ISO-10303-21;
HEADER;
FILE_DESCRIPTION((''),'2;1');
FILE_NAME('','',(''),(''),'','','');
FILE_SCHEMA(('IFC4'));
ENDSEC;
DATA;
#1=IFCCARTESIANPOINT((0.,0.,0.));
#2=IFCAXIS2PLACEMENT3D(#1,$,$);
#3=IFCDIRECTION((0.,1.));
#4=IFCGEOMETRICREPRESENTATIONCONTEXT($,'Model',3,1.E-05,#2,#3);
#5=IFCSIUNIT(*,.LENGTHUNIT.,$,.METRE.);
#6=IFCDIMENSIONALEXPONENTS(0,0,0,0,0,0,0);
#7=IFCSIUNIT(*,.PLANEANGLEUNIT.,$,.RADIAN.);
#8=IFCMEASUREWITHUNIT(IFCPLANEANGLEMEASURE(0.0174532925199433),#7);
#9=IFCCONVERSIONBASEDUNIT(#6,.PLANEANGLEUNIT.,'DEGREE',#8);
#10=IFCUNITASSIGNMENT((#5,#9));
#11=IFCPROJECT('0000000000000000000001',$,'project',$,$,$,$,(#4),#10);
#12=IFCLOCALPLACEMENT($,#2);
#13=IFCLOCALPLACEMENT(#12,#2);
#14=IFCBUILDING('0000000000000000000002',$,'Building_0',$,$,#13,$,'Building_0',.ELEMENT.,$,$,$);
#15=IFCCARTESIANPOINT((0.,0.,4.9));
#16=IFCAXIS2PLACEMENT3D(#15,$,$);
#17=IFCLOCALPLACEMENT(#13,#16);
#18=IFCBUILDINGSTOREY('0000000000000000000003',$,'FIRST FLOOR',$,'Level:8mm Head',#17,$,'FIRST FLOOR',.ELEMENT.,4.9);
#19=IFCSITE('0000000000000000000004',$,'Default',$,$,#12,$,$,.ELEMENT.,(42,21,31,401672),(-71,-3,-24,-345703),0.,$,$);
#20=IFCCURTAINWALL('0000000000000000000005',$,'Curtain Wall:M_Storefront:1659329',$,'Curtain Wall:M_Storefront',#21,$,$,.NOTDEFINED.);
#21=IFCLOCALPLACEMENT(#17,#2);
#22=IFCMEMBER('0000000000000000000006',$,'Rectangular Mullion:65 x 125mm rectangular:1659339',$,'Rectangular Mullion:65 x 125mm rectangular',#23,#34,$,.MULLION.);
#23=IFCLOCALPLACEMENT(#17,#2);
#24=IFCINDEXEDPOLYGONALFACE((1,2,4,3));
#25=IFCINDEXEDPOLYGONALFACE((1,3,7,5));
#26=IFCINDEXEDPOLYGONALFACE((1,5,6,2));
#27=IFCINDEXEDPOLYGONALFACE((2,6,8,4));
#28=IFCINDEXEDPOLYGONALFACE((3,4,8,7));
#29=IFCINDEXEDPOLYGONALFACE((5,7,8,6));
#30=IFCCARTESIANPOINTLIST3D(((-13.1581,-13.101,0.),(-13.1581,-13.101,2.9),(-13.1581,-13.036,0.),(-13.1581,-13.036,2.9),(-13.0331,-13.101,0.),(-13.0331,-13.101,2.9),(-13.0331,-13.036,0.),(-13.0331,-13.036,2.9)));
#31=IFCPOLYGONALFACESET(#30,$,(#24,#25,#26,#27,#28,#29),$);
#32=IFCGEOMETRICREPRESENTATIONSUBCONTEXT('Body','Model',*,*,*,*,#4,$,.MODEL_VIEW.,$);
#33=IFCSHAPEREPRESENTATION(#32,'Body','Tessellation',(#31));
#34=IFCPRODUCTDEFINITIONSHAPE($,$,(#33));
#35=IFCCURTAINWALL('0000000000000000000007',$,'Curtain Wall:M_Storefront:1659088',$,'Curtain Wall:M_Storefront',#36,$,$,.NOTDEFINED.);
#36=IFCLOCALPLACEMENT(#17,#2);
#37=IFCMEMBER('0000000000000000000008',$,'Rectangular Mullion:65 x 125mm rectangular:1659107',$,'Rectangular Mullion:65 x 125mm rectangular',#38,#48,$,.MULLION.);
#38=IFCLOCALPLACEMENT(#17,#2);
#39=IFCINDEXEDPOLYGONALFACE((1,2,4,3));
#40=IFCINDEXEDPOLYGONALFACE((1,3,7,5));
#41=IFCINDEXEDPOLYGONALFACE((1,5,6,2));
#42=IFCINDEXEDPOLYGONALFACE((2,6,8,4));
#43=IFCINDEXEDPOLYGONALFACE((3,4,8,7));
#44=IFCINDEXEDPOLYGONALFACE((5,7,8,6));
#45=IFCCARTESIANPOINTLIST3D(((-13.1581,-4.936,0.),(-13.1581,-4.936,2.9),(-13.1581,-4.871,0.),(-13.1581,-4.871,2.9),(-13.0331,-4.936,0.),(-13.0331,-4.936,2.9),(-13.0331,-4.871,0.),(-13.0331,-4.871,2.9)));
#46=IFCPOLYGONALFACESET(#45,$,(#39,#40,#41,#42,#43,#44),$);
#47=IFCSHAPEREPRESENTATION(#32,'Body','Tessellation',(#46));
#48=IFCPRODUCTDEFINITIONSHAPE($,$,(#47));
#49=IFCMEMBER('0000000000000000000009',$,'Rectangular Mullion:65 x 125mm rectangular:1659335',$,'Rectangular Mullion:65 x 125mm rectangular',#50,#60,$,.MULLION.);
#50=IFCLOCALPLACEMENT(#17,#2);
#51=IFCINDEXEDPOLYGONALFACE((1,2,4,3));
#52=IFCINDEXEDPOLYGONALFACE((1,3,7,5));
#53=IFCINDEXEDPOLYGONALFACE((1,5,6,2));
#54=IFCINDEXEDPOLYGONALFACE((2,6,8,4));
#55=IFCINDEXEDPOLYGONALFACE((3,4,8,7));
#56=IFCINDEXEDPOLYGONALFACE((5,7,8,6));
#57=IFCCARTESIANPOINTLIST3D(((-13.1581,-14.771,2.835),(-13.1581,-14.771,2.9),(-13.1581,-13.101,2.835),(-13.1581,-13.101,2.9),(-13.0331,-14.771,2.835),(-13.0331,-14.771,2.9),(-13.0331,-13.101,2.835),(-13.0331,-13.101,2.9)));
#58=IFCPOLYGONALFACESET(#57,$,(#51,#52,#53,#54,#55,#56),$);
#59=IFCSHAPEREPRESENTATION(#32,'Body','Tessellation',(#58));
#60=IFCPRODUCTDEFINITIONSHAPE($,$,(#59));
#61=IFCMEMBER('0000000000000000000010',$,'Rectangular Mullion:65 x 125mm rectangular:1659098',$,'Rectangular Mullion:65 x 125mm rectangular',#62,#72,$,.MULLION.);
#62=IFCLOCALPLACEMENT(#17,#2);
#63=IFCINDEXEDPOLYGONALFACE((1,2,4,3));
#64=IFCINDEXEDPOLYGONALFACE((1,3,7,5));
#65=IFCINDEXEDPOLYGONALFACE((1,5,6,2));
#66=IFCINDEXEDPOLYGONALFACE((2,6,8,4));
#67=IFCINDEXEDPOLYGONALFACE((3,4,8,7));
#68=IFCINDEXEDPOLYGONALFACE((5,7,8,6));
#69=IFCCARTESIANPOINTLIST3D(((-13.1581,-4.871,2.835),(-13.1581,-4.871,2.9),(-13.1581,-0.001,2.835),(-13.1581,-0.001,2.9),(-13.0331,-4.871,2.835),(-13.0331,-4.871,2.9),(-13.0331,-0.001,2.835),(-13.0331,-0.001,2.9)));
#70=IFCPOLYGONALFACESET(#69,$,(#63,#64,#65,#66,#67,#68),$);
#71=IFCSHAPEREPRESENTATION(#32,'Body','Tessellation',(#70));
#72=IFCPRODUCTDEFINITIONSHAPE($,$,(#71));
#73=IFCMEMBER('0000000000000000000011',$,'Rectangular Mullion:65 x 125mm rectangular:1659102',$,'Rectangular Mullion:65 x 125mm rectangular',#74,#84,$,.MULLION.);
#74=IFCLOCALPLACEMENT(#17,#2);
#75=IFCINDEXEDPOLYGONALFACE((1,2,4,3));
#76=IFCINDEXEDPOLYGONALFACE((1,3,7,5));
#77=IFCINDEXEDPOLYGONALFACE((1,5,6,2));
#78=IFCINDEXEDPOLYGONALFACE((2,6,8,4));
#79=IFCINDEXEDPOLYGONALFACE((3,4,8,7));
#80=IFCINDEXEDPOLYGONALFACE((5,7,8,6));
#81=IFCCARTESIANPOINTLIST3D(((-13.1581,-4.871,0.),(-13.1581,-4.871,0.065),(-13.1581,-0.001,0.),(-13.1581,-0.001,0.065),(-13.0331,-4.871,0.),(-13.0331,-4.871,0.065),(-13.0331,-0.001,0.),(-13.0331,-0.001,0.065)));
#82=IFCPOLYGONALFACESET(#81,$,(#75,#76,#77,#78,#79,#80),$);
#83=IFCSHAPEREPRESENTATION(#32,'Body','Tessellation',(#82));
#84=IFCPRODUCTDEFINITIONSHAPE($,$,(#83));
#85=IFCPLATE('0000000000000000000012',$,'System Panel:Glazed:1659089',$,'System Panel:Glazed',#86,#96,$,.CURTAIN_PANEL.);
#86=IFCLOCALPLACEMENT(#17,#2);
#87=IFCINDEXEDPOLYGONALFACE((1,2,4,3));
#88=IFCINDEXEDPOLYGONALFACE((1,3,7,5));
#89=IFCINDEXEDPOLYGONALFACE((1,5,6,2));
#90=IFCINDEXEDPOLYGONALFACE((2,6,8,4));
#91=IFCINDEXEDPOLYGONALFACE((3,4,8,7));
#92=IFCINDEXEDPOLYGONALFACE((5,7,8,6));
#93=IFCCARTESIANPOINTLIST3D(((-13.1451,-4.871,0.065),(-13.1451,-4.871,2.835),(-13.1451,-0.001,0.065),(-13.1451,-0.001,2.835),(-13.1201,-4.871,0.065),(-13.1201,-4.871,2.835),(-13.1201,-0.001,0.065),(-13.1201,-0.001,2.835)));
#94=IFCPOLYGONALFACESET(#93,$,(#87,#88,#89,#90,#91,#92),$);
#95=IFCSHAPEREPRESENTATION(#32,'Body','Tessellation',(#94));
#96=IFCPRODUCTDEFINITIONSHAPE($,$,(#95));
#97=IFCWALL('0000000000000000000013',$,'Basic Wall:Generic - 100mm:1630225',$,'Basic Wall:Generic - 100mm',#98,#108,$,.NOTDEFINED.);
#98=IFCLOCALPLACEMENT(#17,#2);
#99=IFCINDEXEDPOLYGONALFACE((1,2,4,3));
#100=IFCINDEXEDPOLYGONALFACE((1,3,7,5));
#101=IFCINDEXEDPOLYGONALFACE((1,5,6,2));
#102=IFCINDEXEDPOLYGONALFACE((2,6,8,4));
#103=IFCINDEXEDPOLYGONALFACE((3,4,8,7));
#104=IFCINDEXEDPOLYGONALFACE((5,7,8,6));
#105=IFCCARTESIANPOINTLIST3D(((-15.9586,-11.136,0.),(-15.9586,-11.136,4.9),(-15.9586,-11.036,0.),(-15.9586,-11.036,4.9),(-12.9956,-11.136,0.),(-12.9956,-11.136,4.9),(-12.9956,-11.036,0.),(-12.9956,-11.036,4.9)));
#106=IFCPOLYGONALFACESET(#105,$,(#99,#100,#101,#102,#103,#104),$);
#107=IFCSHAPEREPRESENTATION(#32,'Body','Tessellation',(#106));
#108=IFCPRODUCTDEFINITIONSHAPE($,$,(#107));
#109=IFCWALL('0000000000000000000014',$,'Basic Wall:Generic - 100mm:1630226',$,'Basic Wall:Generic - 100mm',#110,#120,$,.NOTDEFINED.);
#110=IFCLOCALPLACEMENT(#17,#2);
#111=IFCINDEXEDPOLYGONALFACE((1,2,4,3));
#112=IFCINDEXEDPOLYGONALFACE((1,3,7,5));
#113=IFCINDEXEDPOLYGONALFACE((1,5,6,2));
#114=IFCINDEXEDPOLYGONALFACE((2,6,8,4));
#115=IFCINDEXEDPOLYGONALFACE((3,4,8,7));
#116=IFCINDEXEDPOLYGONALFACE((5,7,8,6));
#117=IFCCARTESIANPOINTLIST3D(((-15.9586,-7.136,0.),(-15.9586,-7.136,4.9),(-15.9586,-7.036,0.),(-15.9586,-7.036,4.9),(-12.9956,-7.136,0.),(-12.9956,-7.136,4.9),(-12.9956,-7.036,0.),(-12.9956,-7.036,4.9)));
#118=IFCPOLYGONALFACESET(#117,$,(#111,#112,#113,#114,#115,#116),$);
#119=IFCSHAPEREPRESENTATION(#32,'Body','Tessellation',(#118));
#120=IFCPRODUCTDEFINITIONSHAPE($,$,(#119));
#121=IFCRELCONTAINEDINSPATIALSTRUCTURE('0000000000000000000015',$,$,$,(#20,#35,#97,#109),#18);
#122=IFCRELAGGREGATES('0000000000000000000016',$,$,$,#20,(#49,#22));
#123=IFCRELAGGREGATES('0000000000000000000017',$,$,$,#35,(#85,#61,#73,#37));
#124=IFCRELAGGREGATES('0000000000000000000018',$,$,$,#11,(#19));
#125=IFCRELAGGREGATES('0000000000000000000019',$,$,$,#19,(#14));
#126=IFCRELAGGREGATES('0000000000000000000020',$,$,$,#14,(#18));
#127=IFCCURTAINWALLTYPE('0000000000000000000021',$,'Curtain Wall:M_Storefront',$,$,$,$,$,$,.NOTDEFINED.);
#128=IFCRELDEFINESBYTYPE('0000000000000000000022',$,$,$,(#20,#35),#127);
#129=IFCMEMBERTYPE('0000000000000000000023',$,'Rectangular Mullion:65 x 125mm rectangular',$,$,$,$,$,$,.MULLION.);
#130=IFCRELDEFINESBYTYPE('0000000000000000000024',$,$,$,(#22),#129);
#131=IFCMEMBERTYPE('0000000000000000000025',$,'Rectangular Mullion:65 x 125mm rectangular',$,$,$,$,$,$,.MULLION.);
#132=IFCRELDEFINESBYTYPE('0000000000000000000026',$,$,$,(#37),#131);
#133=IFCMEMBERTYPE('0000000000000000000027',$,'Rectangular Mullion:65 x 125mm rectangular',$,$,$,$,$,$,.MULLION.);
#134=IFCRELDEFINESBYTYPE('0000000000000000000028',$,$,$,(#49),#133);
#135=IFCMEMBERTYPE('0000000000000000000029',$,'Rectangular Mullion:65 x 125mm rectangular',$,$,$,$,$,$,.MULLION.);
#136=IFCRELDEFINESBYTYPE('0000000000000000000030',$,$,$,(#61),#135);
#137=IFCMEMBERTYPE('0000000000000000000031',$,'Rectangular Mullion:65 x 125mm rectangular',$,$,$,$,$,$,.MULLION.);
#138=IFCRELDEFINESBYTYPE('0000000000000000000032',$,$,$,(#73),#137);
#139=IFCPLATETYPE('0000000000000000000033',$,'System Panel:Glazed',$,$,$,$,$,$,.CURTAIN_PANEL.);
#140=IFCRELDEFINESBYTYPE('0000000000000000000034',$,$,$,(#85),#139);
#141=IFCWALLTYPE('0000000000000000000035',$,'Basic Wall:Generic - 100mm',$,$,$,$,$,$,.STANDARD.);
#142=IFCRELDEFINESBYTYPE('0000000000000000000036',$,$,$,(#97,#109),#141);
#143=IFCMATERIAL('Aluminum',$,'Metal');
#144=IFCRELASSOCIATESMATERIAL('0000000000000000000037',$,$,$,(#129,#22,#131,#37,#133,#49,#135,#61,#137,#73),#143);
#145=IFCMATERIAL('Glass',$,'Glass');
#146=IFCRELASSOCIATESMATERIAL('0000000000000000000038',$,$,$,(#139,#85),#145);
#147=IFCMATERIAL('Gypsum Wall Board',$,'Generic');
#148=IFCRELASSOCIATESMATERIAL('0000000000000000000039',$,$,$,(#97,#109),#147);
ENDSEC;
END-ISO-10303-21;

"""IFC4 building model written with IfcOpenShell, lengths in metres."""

from ifc_helpers import new_model, entity, si_unit, converted_unit, direction, frame, origin, place, context, subcontext, project, spatial, indexed_curve, outline, extrude, source, transform, mapped, material, type_object, type_shapes, element, aggregate, save


model = new_model("IFC4")

# Units and contexts
model_context = context("Model", 3, precision=1e-05, world=origin(), true_north=direction((0.0, 1.0)))
body_context = subcontext(model_context, "Body", "Model", "MODEL_VIEW")
ifc_project = project(units=[si_unit("LENGTHUNIT", "METRE"), converted_unit("PLANEANGLEUNIT", "DEGREE", entity("IfcPlaneAngleMeasure", 0.0174532925199433), si_unit("PLANEANGLEUNIT", "RADIAN"), dimensions=[0, 0, 0, 0, 0, 0, 0])], contexts=[model_context])

# Site, building, storey
site_placement = place(None, origin())
site = spatial("IfcSite", under=ifc_project, at=site_placement, Name="Default", CompositionType="ELEMENT", RefLatitude=(42, 21, 31, 401672), RefLongitude=(-71, -3, -24, -345703), RefElevation=0.0)
building_placement = place(site_placement, origin())
building = spatial("IfcBuilding", under=site, at=building_placement, Name="Building_0", LongName="Building_0", CompositionType="ELEMENT")
storey_placement = place(building_placement, frame((0.0, 0.0, 4.9)))
storey = spatial("IfcBuildingStorey", under=building, at=storey_placement, Name="FIRST FLOOR", ObjectType="Level:8mm Head", LongName="FIRST FLOOR", CompositionType="ELEMENT", Elevation=4.9)

# Curtain walls, members
curtain_wall_type = type_object("IfcCurtainWallType", Name="Curtain Wall:M_Storefront", PredefinedType="NOTDEFINED")
curtain_wall_1_placement = place(storey_placement, frame((0.0, 0.0, -4.9)))
curtain_wall_1 = element("IfcCurtainWall", 1, at=curtain_wall_1_placement, inside=storey, type_object=curtain_wall_type, Name="Curtain Wall:M_Storefront:1659329", ObjectType="Curtain Wall:M_Storefront", PredefinedType="NOTDEFINED")
ifc_material_1 = material(Name="Aluminum", Category="Metal")
member_type_1 = type_object("IfcMemberType", Name="Rectangular Mullion:65 x 125mm rectangular", PredefinedType="MULLION", material=ifc_material_1)
shared_shape_1 = source(origin(), body_context, "Body", "SweptSolid", [
    extrude(outline(indexed_curve([(-0.0325, -0.0625), (0.0325, -0.0625), (0.0325, 0.0625), (-0.0325, 0.0625), (-0.0325, -0.0625)], self_intersect=False)), frame((-0.0325, 0.0, -2.9), z_axis=(0.0, 0.0, 1.0), x_axis=(-1.0, 0.0, 0.0)), (0.0, 0.0, 1.0), 2.9),
])
type_shapes(member_type_1, [shared_shape_1])
member_1_placement = place(curtain_wall_1_placement, frame((-13.0956, -13.036, 4.9), z_axis=(0.0, 0.0, -1.0), x_axis=(0.0, 1.0, 0.0)))
member_1 = element("IfcMember", 2, at=member_1_placement, type_object=member_type_1, material=ifc_material_1, Name="Rectangular Mullion:65 x 125mm rectangular:1659339", ObjectType="Rectangular Mullion:65 x 125mm rectangular", PredefinedType="MULLION", context=body_context, shape_type="MappedRepresentation", body=[
    mapped(shared_shape_1, transform((0.0, 0.0, 0.0), scale=1.0)),
])
curtain_wall_2_placement = place(storey_placement, frame((0.0, 0.0, -4.9)))
curtain_wall_2 = element("IfcCurtainWall", 3, at=curtain_wall_2_placement, inside=storey, type_object=curtain_wall_type, Name="Curtain Wall:M_Storefront:1659088", ObjectType="Curtain Wall:M_Storefront", PredefinedType="NOTDEFINED")
member_type_2 = type_object("IfcMemberType", Name="Rectangular Mullion:65 x 125mm rectangular", PredefinedType="MULLION", material=ifc_material_1)
shared_shape_2 = source(origin(), body_context, "Body", "SweptSolid", [
    extrude(outline(indexed_curve([(-0.0325, -0.0625), (0.0325, -0.0625), (0.0325, 0.0625), (-0.0325, 0.0625), (-0.0325, -0.0625)], self_intersect=False)), frame((-0.0325, 0.0, -2.9), z_axis=(0.0, 0.0, 1.0), x_axis=(-1.0, 0.0, 0.0)), (0.0, 0.0, 1.0), 2.9),
])
type_shapes(member_type_2, [shared_shape_2])
member_2_placement = place(curtain_wall_2_placement, frame((-13.0956, -4.936, 7.8), z_axis=(0.0, 0.0, 1.0), x_axis=(0.0, -1.0, 0.0)))
member_2 = element("IfcMember", 4, at=member_2_placement, type_object=member_type_2, material=ifc_material_1, Name="Rectangular Mullion:65 x 125mm rectangular:1659107", ObjectType="Rectangular Mullion:65 x 125mm rectangular", PredefinedType="MULLION", context=body_context, shape_type="MappedRepresentation", body=[
    mapped(shared_shape_2, transform((0.0, 0.0, 0.0), scale=1.0)),
])

# Members
member_type_3 = type_object("IfcMemberType", Name="Rectangular Mullion:65 x 125mm rectangular", PredefinedType="MULLION", material=ifc_material_1)
shared_shape_3 = source(origin(), body_context, "Body", "SweptSolid", [
    extrude(outline(indexed_curve([(-0.0325, -0.0625), (0.0325, -0.0625), (0.0325, 0.0625), (-0.0325, 0.0625), (-0.0325, -0.0625)], self_intersect=False)), frame((-0.0325, 0.0, -1.67), z_axis=(0.0, 0.0, 1.0), x_axis=(-1.0, 0.0, 0.0)), (0.0, 0.0, 1.0), 1.67),
])
type_shapes(member_type_3, [shared_shape_3])
member_3_placement = place(curtain_wall_1_placement, frame((-13.0956, -13.101, 7.8), z_axis=(0.0, 1.0, 0.0), x_axis=(0.0, 0.0, 1.0)))
member_3 = element("IfcMember", 5, at=member_3_placement, type_object=member_type_3, material=ifc_material_1, Name="Rectangular Mullion:65 x 125mm rectangular:1659335", ObjectType="Rectangular Mullion:65 x 125mm rectangular", PredefinedType="MULLION", context=body_context, shape_type="MappedRepresentation", body=[
    mapped(shared_shape_3, transform((0.0, 0.0, 0.0), scale=1.0)),
])
aggregate(curtain_wall_1, [member_3, member_1])
member_type_4 = type_object("IfcMemberType", Name="Rectangular Mullion:65 x 125mm rectangular", PredefinedType="MULLION", material=ifc_material_1)
shared_shape_4 = source(origin(), body_context, "Body", "SweptSolid", [
    extrude(outline(indexed_curve([(-0.0325, -0.0625), (0.0325, -0.0625), (0.0325, 0.0625), (-0.0325, 0.0625), (-0.0325, -0.0625)], self_intersect=False)), frame((-0.0325, 0.0, -4.87), z_axis=(0.0, 0.0, 1.0), x_axis=(-1.0, 0.0, 0.0)), (0.0, 0.0, 1.0), 4.87),
])
type_shapes(member_type_4, [shared_shape_4])
member_4_placement = place(curtain_wall_2_placement, frame((-13.0956, -0.001, 7.8), z_axis=(0.0, 1.0, 0.0), x_axis=(0.0, 0.0, 1.0)))
member_4 = element("IfcMember", 6, at=member_4_placement, type_object=member_type_4, material=ifc_material_1, Name="Rectangular Mullion:65 x 125mm rectangular:1659098", ObjectType="Rectangular Mullion:65 x 125mm rectangular", PredefinedType="MULLION", context=body_context, shape_type="MappedRepresentation", body=[
    mapped(shared_shape_4, transform((0.0, 0.0, 0.0), scale=1.0)),
])
member_type_5 = type_object("IfcMemberType", Name="Rectangular Mullion:65 x 125mm rectangular", PredefinedType="MULLION", material=ifc_material_1)
shared_shape_5 = source(origin(), body_context, "Body", "SweptSolid", [
    extrude(outline(indexed_curve([(-0.0325, -0.0625), (0.0325, -0.0625), (0.0325, 0.0625), (-0.0325, 0.0625), (-0.0325, -0.0625)], self_intersect=False)), frame((-0.0325, 0.0, -4.87), z_axis=(0.0, 0.0, 1.0), x_axis=(-1.0, 0.0, 0.0)), (0.0, 0.0, 1.0), 4.87),
])
type_shapes(member_type_5, [shared_shape_5])
member_5_placement = place(curtain_wall_2_placement, frame((-13.0956, -4.871, 4.9), z_axis=(0.0, -1.0, 0.0), x_axis=(0.0, 0.0, -1.0)))
member_5 = element("IfcMember", 7, at=member_5_placement, type_object=member_type_5, material=ifc_material_1, Name="Rectangular Mullion:65 x 125mm rectangular:1659102", ObjectType="Rectangular Mullion:65 x 125mm rectangular", PredefinedType="MULLION", context=body_context, shape_type="MappedRepresentation", body=[
    mapped(shared_shape_5, transform((0.0, 0.0, 0.0), scale=1.0)),
])

# Plate
ifc_material_2 = material(Name="Glass", Category="Glass")
plate_type = type_object("IfcPlateType", Name="System Panel:Glazed", PredefinedType="CURTAIN_PANEL", material=ifc_material_2)
shared_shape_6 = source(origin(), body_context, "Body", "SweptSolid", [
    extrude(outline(indexed_curve([(-0.0125, -2.435), (0.0125, -2.435), (0.0125, 2.435), (-0.0125, 2.435), (-0.0125, -2.435)], self_intersect=False)), frame((0.0, 0.037, 0.0), z_axis=(0.0, 0.0, 1.0), x_axis=(0.0, 1.0, 0.0)), (0.0, 0.0, 1.0), 2.77),
])
type_shapes(plate_type, [shared_shape_6])
plate_placement = place(curtain_wall_2_placement, frame((-13.0956, -2.436, 4.965), z_axis=(0.0, 0.0, 1.0), x_axis=(0.0, 1.0, 0.0)))
plate = element("IfcPlate", 8, at=plate_placement, type_object=plate_type, material=ifc_material_2, Name="System Panel:Glazed:1659089", ObjectType="System Panel:Glazed", PredefinedType="CURTAIN_PANEL", context=body_context, shape_type="MappedRepresentation", body=[
    mapped(shared_shape_6, transform((0.0, 0.0, 0.0), scale=1.0)),
])
aggregate(curtain_wall_2, [plate, member_4, member_5, member_2])

# Walls
ifc_material_3 = material(Name="Gypsum Wall Board", Category="Generic")
wall_type_1 = type_object("IfcWallType", Name="Basic Wall:Generic - 100mm", PredefinedType="STANDARD")
wall_1_placement = place(storey_placement, frame((-15.9586, -11.086, 0.0)))
element("IfcWall", 9, at=wall_1_placement, inside=storey, type_object=wall_type_1, material=ifc_material_3, Name="Basic Wall:Generic - 100mm:1630225", ObjectType="Basic Wall:Generic - 100mm", PredefinedType="NOTDEFINED", context=body_context, shape_type="SweptSolid", body=[
    extrude(outline(indexed_curve([(2.963, 0.05), (0.0, 0.05), (0.0, -0.05), (2.963, -0.05), (2.963, 0.05)], self_intersect=False)), origin(), (0.0, 0.0, 1.0), 4.9),
])
wall_2_placement = place(storey_placement, frame((-15.9586, -7.086, 0.0)))
element("IfcWall", 10, at=wall_2_placement, inside=storey, type_object=wall_type_1, material=ifc_material_3, Name="Basic Wall:Generic - 100mm:1630226", ObjectType="Basic Wall:Generic - 100mm", PredefinedType="NOTDEFINED", context=body_context, shape_type="SweptSolid", body=[
    extrude(outline(indexed_curve([(2.963, 0.05), (0.0, 0.05), (0.0, -0.05), (2.963, -0.05), (2.963, 0.05)], self_intersect=False)), origin(), (0.0, 0.0, 1.0), 4.9),
])

save(model, "model.ifc")
